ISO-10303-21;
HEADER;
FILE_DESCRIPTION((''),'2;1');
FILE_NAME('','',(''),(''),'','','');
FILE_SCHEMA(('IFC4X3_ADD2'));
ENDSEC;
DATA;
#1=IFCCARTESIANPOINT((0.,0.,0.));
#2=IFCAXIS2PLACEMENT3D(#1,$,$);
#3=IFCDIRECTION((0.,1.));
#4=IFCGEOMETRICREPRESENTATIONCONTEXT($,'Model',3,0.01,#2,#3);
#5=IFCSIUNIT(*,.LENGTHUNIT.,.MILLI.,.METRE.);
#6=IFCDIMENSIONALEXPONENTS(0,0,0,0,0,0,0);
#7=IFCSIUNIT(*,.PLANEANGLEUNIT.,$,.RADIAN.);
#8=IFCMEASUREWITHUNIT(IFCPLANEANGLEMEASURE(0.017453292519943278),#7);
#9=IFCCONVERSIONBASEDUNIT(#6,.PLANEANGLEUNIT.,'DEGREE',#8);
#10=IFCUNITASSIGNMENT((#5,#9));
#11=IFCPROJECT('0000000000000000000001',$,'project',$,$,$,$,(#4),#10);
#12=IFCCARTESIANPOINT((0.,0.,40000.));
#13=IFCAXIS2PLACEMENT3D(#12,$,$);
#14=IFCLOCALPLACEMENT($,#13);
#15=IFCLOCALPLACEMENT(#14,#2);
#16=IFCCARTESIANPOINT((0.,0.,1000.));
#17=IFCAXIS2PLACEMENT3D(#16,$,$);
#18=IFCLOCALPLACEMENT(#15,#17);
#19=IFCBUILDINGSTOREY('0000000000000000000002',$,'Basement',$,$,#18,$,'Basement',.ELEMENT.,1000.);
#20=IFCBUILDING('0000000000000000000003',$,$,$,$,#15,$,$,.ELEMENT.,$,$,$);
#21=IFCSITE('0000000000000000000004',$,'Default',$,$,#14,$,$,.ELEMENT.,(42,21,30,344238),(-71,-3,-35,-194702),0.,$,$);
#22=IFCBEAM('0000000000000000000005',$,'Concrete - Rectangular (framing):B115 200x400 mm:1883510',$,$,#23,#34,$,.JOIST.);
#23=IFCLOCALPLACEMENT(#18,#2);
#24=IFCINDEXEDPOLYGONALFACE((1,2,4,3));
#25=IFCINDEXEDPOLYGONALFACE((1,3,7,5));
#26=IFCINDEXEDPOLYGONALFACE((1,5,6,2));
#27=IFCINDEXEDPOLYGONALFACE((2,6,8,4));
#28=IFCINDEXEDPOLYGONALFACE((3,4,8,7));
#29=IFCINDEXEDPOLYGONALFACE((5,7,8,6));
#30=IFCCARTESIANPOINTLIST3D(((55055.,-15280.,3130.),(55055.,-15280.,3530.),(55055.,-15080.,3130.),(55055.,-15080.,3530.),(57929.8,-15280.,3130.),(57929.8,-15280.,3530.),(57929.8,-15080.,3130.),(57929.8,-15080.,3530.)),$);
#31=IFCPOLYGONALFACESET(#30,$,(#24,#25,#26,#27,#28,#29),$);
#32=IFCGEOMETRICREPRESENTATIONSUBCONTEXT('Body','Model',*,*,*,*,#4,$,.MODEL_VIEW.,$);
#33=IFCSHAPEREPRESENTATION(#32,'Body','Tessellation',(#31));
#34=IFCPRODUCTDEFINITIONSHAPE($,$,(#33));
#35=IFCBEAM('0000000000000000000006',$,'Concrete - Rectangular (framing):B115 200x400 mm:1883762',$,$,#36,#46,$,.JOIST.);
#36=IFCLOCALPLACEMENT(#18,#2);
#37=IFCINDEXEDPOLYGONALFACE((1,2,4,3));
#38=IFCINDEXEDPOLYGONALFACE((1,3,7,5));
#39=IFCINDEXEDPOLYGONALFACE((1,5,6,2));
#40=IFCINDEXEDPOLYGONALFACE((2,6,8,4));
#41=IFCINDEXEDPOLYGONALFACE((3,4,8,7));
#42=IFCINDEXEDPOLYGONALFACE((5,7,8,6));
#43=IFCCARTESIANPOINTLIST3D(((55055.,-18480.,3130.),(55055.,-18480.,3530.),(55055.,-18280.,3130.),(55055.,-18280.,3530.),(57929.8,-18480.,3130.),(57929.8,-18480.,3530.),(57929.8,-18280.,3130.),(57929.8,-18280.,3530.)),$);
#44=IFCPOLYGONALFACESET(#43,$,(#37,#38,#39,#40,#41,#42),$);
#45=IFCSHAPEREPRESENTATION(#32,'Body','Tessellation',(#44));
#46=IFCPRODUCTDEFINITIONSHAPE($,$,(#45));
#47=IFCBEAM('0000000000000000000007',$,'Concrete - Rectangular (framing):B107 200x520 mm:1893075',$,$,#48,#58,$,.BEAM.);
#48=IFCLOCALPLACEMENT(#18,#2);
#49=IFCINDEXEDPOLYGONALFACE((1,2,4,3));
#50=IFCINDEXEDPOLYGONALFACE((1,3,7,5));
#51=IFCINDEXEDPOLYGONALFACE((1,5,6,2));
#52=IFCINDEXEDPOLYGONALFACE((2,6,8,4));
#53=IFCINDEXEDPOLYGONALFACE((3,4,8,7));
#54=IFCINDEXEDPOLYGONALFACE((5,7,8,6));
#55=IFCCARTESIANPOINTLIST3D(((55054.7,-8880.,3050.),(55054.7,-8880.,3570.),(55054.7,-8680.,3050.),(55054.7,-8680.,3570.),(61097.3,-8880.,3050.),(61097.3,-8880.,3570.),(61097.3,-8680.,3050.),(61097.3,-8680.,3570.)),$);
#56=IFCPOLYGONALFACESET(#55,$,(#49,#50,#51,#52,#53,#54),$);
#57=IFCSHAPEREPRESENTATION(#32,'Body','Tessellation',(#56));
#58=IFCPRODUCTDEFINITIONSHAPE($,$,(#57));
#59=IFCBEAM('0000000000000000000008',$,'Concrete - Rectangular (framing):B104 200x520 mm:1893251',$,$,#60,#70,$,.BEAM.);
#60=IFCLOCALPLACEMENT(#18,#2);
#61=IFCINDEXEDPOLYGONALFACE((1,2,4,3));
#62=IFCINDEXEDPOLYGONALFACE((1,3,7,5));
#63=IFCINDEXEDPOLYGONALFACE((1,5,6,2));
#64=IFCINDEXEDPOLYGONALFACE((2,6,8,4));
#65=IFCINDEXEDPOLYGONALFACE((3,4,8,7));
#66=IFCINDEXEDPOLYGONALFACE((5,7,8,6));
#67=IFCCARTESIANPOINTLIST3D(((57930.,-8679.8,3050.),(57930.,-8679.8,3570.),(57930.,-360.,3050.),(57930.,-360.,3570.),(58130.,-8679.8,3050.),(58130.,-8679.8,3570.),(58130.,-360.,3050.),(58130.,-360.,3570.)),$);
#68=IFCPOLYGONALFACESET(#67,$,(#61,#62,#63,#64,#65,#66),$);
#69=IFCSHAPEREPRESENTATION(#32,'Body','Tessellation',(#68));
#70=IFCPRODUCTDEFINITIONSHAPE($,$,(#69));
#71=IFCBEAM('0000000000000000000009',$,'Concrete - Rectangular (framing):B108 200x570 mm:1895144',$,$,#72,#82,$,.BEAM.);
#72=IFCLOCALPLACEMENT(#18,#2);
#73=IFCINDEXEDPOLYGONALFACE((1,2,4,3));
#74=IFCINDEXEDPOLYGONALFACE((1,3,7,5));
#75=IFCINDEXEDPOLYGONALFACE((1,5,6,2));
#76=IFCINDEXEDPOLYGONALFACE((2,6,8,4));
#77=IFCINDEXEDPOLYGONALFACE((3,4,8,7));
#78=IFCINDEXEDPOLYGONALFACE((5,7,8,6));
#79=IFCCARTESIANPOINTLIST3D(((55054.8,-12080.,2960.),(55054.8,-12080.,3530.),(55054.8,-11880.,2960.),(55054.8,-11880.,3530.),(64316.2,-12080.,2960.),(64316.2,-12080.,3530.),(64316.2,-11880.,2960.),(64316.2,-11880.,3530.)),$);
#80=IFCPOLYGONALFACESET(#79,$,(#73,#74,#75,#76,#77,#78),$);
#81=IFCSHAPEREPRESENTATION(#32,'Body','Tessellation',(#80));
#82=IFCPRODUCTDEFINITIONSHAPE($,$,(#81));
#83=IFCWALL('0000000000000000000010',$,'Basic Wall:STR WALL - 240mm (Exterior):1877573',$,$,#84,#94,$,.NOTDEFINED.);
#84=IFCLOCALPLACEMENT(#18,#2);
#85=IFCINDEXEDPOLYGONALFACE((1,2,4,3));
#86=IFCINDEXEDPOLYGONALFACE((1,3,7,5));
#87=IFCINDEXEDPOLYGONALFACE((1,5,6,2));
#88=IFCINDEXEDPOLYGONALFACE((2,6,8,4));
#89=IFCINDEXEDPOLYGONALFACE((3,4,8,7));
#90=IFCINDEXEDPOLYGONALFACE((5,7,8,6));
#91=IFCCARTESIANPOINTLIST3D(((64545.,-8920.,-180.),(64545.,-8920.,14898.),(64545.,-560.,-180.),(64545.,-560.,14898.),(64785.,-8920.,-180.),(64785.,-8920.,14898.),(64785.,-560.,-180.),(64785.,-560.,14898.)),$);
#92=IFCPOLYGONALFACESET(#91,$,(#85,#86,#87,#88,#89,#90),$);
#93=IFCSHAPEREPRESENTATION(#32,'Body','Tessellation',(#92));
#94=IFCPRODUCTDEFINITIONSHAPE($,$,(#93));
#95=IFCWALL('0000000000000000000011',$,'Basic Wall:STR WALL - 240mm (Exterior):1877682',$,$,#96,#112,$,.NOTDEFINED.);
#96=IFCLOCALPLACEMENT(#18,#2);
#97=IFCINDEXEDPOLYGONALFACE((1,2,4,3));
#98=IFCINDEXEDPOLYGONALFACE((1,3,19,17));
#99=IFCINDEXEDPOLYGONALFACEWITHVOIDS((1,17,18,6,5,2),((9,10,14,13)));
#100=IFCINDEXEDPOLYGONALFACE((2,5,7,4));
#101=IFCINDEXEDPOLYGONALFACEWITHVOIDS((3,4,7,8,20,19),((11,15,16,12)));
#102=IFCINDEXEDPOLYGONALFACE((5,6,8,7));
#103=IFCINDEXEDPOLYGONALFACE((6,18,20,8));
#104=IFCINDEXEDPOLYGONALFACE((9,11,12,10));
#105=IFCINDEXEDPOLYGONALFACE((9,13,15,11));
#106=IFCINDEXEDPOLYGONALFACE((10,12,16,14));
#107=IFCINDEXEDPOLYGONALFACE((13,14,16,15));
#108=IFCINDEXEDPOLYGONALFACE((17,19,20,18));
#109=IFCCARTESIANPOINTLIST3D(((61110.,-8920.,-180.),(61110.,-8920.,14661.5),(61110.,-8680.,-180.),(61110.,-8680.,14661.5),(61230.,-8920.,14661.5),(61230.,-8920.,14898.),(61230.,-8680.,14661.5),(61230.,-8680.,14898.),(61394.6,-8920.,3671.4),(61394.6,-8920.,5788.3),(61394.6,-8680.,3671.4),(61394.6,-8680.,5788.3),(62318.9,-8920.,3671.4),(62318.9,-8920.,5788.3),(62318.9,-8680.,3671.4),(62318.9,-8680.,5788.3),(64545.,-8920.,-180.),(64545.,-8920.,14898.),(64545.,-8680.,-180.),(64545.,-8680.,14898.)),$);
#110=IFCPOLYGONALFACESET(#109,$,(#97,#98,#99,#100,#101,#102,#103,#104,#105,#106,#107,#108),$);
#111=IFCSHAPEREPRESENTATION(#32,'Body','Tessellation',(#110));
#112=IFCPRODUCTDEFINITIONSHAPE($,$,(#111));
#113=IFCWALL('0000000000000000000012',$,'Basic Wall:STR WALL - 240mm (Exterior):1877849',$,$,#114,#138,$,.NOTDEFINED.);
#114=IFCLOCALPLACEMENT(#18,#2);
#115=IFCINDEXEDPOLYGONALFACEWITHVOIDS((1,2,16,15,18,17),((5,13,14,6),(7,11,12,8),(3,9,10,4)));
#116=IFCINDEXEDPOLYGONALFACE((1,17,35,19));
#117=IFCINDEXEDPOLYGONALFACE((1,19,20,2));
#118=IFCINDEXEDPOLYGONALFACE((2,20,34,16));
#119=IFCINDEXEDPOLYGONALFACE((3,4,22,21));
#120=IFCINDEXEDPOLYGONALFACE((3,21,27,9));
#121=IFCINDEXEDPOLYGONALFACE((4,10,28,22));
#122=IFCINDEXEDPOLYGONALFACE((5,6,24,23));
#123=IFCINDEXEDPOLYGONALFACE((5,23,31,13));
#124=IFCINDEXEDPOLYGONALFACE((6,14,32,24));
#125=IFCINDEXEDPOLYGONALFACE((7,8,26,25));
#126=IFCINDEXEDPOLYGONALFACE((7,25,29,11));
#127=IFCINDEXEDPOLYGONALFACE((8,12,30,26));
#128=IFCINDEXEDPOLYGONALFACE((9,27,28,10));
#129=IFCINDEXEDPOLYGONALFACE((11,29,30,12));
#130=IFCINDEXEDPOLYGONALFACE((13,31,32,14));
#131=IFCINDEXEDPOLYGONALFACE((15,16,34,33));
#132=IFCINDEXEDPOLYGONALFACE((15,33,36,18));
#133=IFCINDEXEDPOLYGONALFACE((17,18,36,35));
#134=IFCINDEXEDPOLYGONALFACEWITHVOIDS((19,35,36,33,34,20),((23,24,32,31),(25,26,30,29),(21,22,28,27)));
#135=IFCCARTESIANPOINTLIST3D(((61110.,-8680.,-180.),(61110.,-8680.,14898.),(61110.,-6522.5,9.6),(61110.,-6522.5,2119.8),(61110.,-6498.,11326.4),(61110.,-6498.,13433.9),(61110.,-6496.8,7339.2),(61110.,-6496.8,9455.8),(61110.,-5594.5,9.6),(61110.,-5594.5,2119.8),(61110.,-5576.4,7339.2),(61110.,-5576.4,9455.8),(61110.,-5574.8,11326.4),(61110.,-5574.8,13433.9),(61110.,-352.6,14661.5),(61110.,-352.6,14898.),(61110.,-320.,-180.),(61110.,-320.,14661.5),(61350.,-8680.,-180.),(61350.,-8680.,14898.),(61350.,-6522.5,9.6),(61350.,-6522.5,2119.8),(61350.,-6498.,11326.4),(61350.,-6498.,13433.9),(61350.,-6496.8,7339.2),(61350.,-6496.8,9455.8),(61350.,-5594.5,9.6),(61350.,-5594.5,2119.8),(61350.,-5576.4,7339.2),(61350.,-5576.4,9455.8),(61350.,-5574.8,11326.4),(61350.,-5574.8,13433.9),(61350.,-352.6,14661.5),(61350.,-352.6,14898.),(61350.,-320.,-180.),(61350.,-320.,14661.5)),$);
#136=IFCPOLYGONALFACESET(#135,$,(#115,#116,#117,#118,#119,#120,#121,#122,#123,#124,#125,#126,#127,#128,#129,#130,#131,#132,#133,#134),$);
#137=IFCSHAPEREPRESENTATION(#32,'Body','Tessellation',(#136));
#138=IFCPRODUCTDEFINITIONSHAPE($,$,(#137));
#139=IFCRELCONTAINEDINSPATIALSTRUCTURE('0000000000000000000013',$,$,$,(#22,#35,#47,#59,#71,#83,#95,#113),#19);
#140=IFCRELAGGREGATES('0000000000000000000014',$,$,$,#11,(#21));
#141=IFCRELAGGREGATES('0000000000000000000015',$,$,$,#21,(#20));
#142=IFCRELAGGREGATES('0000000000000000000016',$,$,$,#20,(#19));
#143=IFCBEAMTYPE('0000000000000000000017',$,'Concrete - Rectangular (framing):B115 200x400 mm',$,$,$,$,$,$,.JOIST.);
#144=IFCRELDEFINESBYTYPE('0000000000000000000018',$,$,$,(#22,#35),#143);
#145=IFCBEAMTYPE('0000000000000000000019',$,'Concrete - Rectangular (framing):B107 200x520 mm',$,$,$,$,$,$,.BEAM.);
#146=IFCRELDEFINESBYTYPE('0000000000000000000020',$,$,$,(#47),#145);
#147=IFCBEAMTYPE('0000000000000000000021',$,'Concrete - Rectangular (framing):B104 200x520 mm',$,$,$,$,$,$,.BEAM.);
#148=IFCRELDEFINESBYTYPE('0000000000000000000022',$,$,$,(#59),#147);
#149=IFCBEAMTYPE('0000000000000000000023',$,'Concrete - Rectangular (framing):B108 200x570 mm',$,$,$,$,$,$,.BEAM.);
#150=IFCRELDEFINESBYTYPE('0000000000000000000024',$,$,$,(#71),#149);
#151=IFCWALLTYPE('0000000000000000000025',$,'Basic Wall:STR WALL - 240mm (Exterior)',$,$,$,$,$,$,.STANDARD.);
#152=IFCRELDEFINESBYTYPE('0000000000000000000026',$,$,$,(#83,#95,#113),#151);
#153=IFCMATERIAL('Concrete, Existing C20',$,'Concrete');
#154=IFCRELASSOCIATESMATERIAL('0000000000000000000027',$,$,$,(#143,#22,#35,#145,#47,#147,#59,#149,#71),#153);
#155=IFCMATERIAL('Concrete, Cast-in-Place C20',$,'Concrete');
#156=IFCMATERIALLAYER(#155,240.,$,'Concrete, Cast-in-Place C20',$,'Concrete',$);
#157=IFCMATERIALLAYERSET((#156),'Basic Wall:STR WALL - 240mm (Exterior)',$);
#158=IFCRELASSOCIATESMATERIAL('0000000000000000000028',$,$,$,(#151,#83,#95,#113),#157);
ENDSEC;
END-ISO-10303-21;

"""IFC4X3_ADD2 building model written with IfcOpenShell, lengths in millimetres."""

from ifc_helpers import new_model, entity, si_unit, converted_unit, direction, frame, frame_2d, origin, origin_2d_with_axis, place, context, subcontext, project, spatial, polyline, rectangle, extrude, clip, bounded_halfspace, source, transform, mapped, material, layer, layer_set, material_profile, profile_set, profile_usage, type_object, type_shapes, element, save


model = new_model("IFC4X3_ADD2")

# Units and contexts
model_context = context("Model", 3, precision=0.01, world=origin(), true_north=direction((0.0, 1.0)))
body_context = subcontext(model_context, "Body", "Model", "MODEL_VIEW")
ifc_project = project(units=[si_unit("LENGTHUNIT", "METRE", prefix="MILLI"), converted_unit("PLANEANGLEUNIT", "DEGREE", entity("IfcPlaneAngleMeasure", 0.017453292519943278), si_unit("PLANEANGLEUNIT", "RADIAN"), dimensions=[0, 0, 0, 0, 0, 0, 0])], contexts=[model_context])

# Site, building, storey
site_placement = place(None, frame((0.0, 0.0, 40000.0)))
site = spatial("IfcSite", under=ifc_project, at=site_placement, Name="Default", CompositionType="ELEMENT", RefLatitude=(42, 21, 30, 344238), RefLongitude=(-71, -3, -35, -194702), RefElevation=0.0)
building_placement = place(site_placement, origin())
building = spatial("IfcBuilding", under=site, at=building_placement, CompositionType="ELEMENT")
storey_placement = place(building_placement, frame((0.0, 0.0, 1000.0)))
storey = spatial("IfcBuildingStorey", under=building, at=storey_placement, Name="Basement", LongName="Basement", CompositionType="ELEMENT", Elevation=1000.0)

# Shared definitions
ifc_material_1 = material(Name="Concrete, Existing C20", Category="Concrete")

# Beams
ifc_material_profile_1 = material_profile(ifc_material_1, rectangle(XDim=2874.8, YDim=200.0, at=frame_2d((0.0, 0.0), x_axis=(1.0, 0.0))), Name="B115 200x400 mm")
ifc_profile_set_1 = profile_set([ifc_material_profile_1], Name="B115 200x400 mm")
ifc_profile_usage_1 = profile_usage(ifc_profile_set_1, cardinal=8)
beam_type_1 = type_object("IfcBeamType", Name="Concrete - Rectangular (framing):B115 200x400 mm", PredefinedType="JOIST", material=ifc_profile_set_1)
shared_shape_1 = source(origin(), body_context, "Body", "SweptSolid", [
    extrude(rectangle(XDim=2874.8, YDim=200.0, at=frame_2d((0.0, 0.0), x_axis=(1.0, 0.0))), frame((-125.1, 0.0, -200.0), z_axis=(0.0, 0.0, 1.0), x_axis=(-1.0, 0.0, 0.0)), (0.0, 0.0, 1.0), 400.0),
])
type_shapes(beam_type_1, [shared_shape_1])
for number, where, name in (
    (1, (56617.5, -15180.0, 3330.0), "Concrete - Rectangular (framing):B115 200x400 mm:1883510"),
    (2, (56617.5, -18380.0, 3330.0), "Concrete - Rectangular (framing):B115 200x400 mm:1883762"),
):
    element("IfcBeam", number, at=place(storey_placement, frame(where)), inside=storey, type_object=beam_type_1, material=ifc_profile_usage_1, Name=name, PredefinedType="JOIST", context=body_context, shape_type="MappedRepresentation", body=[
        mapped(shared_shape_1, transform((0.0, 0.0, 0.0), scale=1.0)),
    ])
ifc_material_profile_2 = material_profile(ifc_material_1, rectangle(XDim=6042.6, YDim=200.0, at=origin_2d_with_axis()), Name="B107 200x520 mm")
ifc_profile_set_2 = profile_set([ifc_material_profile_2], Name="B107 200x520 mm")
ifc_profile_usage_2 = profile_usage(ifc_profile_set_2, cardinal=8)
beam_type_2 = type_object("IfcBeamType", Name="Concrete - Rectangular (framing):B107 200x520 mm", PredefinedType="BEAM", material=ifc_profile_set_2)
shared_shape_2 = source(origin(), body_context, "Body", "SweptSolid", [
    extrude(rectangle(XDim=6042.6, YDim=200.0, at=origin_2d_with_axis()), frame((154.0, 0.0, -260.0), z_axis=(0.0, 0.0, 1.0), x_axis=(-1.0, 0.0, 0.0)), (0.0, 0.0, 1.0), 520.0),
])
type_shapes(beam_type_2, [shared_shape_2])
beam_1_placement = place(storey_placement, frame((58230.0, -8780.0, 3310.0), z_axis=(0.0, 0.0, 1.0), x_axis=(-1.0, 0.0, 0.0)))
element("IfcBeam", 3, at=beam_1_placement, inside=storey, type_object=beam_type_2, material=ifc_profile_usage_2, Name="Concrete - Rectangular (framing):B107 200x520 mm:1893075", PredefinedType="BEAM", context=body_context, shape_type="MappedRepresentation", body=[
    mapped(shared_shape_2, transform((0.0, 0.0, 0.0), scale=1.0)),
])
ifc_material_profile_3 = material_profile(ifc_material_1, rectangle(XDim=8319.8, YDim=200.0, at=origin_2d_with_axis()), Name="B104 200x520 mm")
ifc_profile_set_3 = profile_set([ifc_material_profile_3], Name="B104 200x520 mm")
ifc_profile_usage_3 = profile_usage(ifc_profile_set_3, cardinal=8)
beam_type_3 = type_object("IfcBeamType", Name="Concrete - Rectangular (framing):B104 200x520 mm", PredefinedType="BEAM", material=ifc_profile_set_3)
shared_shape_3 = source(origin(), body_context, "Body", "SweptSolid", [
    extrude(rectangle(XDim=8319.8, YDim=200.0, at=origin_2d_with_axis()), frame((-100.1, 0.0, -260.0), z_axis=(0.0, 0.0, 1.0), x_axis=(-1.0, 0.0, 0.0)), (0.0, 0.0, 1.0), 520.0),
])
type_shapes(beam_type_3, [shared_shape_3])
beam_2_placement = place(storey_placement, frame((58030.0, -4620.0, 3310.0), z_axis=(0.0, 0.0, 1.0), x_axis=(0.0, -1.0, 0.0)))
element("IfcBeam", 4, at=beam_2_placement, inside=storey, type_object=beam_type_3, material=ifc_profile_usage_3, Name="Concrete - Rectangular (framing):B104 200x520 mm:1893251", PredefinedType="BEAM", context=body_context, shape_type="MappedRepresentation", body=[
    mapped(shared_shape_3, transform((0.0, 0.0, 0.0), scale=1.0)),
])
ifc_material_profile_4 = material_profile(ifc_material_1, rectangle(XDim=9261.4, YDim=200.0, at=origin_2d_with_axis()), Name="B108 200x570 mm")
ifc_profile_set_4 = profile_set([ifc_material_profile_4], Name="B108 200x570 mm")
ifc_profile_usage_4 = profile_usage(ifc_profile_set_4, cardinal=8)
beam_type_4 = type_object("IfcBeamType", Name="Concrete - Rectangular (framing):B108 200x570 mm", PredefinedType="BEAM", material=ifc_profile_set_4)
shared_shape_4 = source(origin(), body_context, "Body", "SweptSolid", [
    extrude(rectangle(XDim=9261.4, YDim=200.0, at=origin_2d_with_axis()), frame((43.0, 0.0, -285.0), z_axis=(0.0, 0.0, 1.0), x_axis=(-1.0, 0.0, 0.0)), (0.0, 0.0, 1.0), 570.0),
])
type_shapes(beam_type_4, [shared_shape_4])
beam_3_placement = place(storey_placement, frame((59642.5, -11980.0, 3245.0)))
element("IfcBeam", 5, at=beam_3_placement, inside=storey, type_object=beam_type_4, material=ifc_profile_usage_4, Name="Concrete - Rectangular (framing):B108 200x570 mm:1895144", PredefinedType="BEAM", context=body_context, shape_type="MappedRepresentation", body=[
    mapped(shared_shape_4, transform((0.0, 0.0, 0.0), scale=1.0)),
])

# Wall
ifc_material_2 = material(Name="Concrete, Cast-in-Place C20", Category="Concrete")
ifc_layer = layer(ifc_material_2, 240.0, Name="Concrete, Cast-in-Place C20", Category="Concrete")
ifc_layer_set = layer_set([ifc_layer], Name="Basic Wall:STR WALL - 240mm (Exterior)")
wall_type = type_object("IfcWallType", Name="Basic Wall:STR WALL - 240mm (Exterior)", PredefinedType="STANDARD", material=ifc_layer_set)
wall_1_placement = place(storey_placement, frame((64665.0, -560.0, -180.0), z_axis=(0.0, 0.0, 1.0), x_axis=(0.0, -1.0, 0.0)))
element("IfcWall", 6, at=wall_1_placement, inside=storey, type_object=wall_type, material=ifc_layer_set, Name="Basic Wall:STR WALL - 240mm (Exterior):1877573", PredefinedType="NOTDEFINED", context=body_context, shape_type="SweptSolid", body=[
    extrude(rectangle(XDim=8360.0, YDim=240.0, at=frame_2d((4180.0, 0.0), x_axis=(-1.0, 0.0))), origin(), (0.0, 0.0, 1.0), 15078.0),
])

# Wall, opening
wall_2_placement = place(storey_placement, frame((64545.0, -8800.0, -180.0), z_axis=(0.0, 0.0, 1.0), x_axis=(-1.0, 0.0, 0.0)))
wall_2 = element("IfcWall", 7, at=wall_2_placement, inside=storey, type_object=wall_type, material=ifc_layer_set, Name="Basic Wall:STR WALL - 240mm (Exterior):1877682", PredefinedType="NOTDEFINED", context=body_context, shape_type="Clipping", body=[
    clip(clip(clip(clip(extrude(rectangle(XDim=3435.0, YDim=240.0, at=frame_2d((1717.5, 0.0), x_axis=(-1.0, 0.0))), origin(), (0.0, 0.0, 1.0), 15078.0), bounded_halfspace(frame((3315.0, -7.6, 15078.0), z_axis=(0.0, 0.0, -1.0), x_axis=(0.0, 1.0, 0.0)), True, frame((3315.0, -7.6, 15078.0)), polyline([(0.0, 0.0), (0.0, 127.6), (-3315.0, 127.6), (-3315.0, 0.0), (0.0, 0.0)]))), bounded_halfspace(frame((0.0, -120.0, 15078.0), z_axis=(0.0, 0.0, -1.0), x_axis=(0.0, 1.0, 0.0)), True, frame((0.0, -120.0, 15078.0)), polyline([(0.0, 0.0), (3195.0, 0.0), (3315.0, 0.0), (3315.0, 112.4), (0.0, 112.4), (0.0, 0.0)]))), bounded_halfspace(frame((3315.0, -120.0, 14841.5), z_axis=(0.0, 0.0, 1.0), x_axis=(0.0, 1.0, 0.0)), False, frame((3315.0, -120.0, 14841.5)), polyline([(0.0, 0.0), (120.0, 0.0), (120.0, 112.4), (0.0, 112.4), (0.0, 0.0)]))), bounded_halfspace(frame((3435.0, -7.6, 14841.5), z_axis=(0.0, 0.0, 1.0), x_axis=(0.0, 1.0, 0.0)), False, frame((3435.0, -7.6, 14841.5)), polyline([(0.0, 0.0), (0.0, 127.6), (-120.0, 127.6), (-120.0, 0.0), (0.0, 0.0)]))),
])
opening_1_placement = place(wall_2_placement, frame((3150.4, 120.0, 3851.4)))
element("IfcOpeningElement", 8, at=opening_1_placement, cuts=wall_2, PredefinedType="OPENING", context=body_context, shape_type="SweptSolid", body=[
    extrude(rectangle(XDim=2116.9, YDim=924.3, at=frame_2d((0.0, 0.0), x_axis=(1.0, 0.0))), frame((-462.1, -240.0, 1058.4), z_axis=(0.0, 1.0, 0.0), x_axis=(0.0, 0.0, -1.0)), (0.0, 0.0, 1.0), 240.0),
])

# Wall, openings
wall_3_placement = place(storey_placement, frame((61230.0, -8680.0, -180.0), z_axis=(0.0, 0.0, 1.0), x_axis=(0.0, 1.0, 0.0)))
wall_3 = element("IfcWall", 9, at=wall_3_placement, inside=storey, type_object=wall_type, material=ifc_layer_set, Name="Basic Wall:STR WALL - 240mm (Exterior):1877849", PredefinedType="NOTDEFINED", context=body_context, shape_type="Clipping", body=[
    clip(clip(clip(clip(extrude(rectangle(XDim=8360.0, YDim=240.0, at=frame_2d((4180.0, 0.0), x_axis=(-1.0, 0.0))), origin(), (0.0, 0.0, 1.0), 15078.0), bounded_halfspace(frame((0.0, -120.0, 15078.0), z_axis=(0.0, 0.0, -1.0), x_axis=(-1.0, 0.0, 0.0)), True, frame((0.0, -120.0, 15078.0)), polyline([(0.0, 0.0), (8120.0, 0.0), (8327.4, 0.0), (8327.4, 120.0), (0.0, 120.0), (0.0, 0.0)]))), bounded_halfspace(frame((8327.4, 120.0, 15078.0), z_axis=(0.0, 0.0, -1.0), x_axis=(-1.0, 0.0, 0.0)), True, frame((8327.4, 120.0, 15078.0)), polyline([(0.0, 0.0), (-8327.4, 0.0), (-8327.4, -120.0), (0.0, -120.0), (0.0, 0.0)]))), bounded_halfspace(frame((8327.4, -120.0, 14841.5), z_axis=(0.0, 0.0, 1.0), x_axis=(0.0, 1.0, 0.0)), False, frame((8327.4, -120.0, 14841.5)), polyline([(0.0, 0.0), (32.6, 0.0), (32.6, 120.0), (0.0, 120.0), (0.0, 0.0)]))), bounded_halfspace(frame((8360.0, 0.0, 14841.5), z_axis=(0.0, 0.0, 1.0), x_axis=(0.0, 1.0, 0.0)), False, frame((8360.0, 0.0, 14841.5)), polyline([(0.0, 0.0), (0.0, 120.0), (-32.6, 120.0), (-32.6, 0.0), (0.0, 0.0)]))),
])
opening_2_placement = place(wall_3_placement, frame((2182.0, 120.0, 11506.4)))
element("IfcOpeningElement", 10, at=opening_2_placement, cuts=wall_3, PredefinedType="OPENING", context=body_context, shape_type="SweptSolid", body=[
    extrude(rectangle(XDim=2107.5, YDim=923.2, at=origin_2d_with_axis()), frame((461.6, -240.0, 1053.8), z_axis=(0.0, 1.0, 0.0), x_axis=(0.0, 0.0, -1.0)), (0.0, 0.0, 1.0), 240.0),
])
opening_3_placement = place(wall_3_placement, frame((2183.2, 120.0, 7519.2)))
element("IfcOpeningElement", 11, at=opening_3_placement, cuts=wall_3, PredefinedType="OPENING", context=body_context, shape_type="SweptSolid", body=[
    extrude(rectangle(XDim=2116.6, YDim=920.4, at=frame_2d((0.0, 0.0), x_axis=(1.0, 0.0))), frame((460.2, -240.0, 1058.3), z_axis=(0.0, 1.0, 0.0), x_axis=(0.0, 0.0, -1.0)), (0.0, 0.0, 1.0), 240.0),
])
opening_4_placement = place(wall_3_placement, frame((2157.5, 120.0, 189.6)))
element("IfcOpeningElement", 12, at=opening_4_placement, cuts=wall_3, PredefinedType="OPENING", context=body_context, shape_type="SweptSolid", body=[
    extrude(rectangle(XDim=2110.2, YDim=928.0, at=frame_2d((0.0, 0.0), x_axis=(1.0, 0.0))), frame((464.0, -240.0, 1055.1), z_axis=(0.0, 1.0, 0.0), x_axis=(0.0, 0.0, -1.0)), (0.0, 0.0, 1.0), 240.0),
])

save(model, "model.ifc")
